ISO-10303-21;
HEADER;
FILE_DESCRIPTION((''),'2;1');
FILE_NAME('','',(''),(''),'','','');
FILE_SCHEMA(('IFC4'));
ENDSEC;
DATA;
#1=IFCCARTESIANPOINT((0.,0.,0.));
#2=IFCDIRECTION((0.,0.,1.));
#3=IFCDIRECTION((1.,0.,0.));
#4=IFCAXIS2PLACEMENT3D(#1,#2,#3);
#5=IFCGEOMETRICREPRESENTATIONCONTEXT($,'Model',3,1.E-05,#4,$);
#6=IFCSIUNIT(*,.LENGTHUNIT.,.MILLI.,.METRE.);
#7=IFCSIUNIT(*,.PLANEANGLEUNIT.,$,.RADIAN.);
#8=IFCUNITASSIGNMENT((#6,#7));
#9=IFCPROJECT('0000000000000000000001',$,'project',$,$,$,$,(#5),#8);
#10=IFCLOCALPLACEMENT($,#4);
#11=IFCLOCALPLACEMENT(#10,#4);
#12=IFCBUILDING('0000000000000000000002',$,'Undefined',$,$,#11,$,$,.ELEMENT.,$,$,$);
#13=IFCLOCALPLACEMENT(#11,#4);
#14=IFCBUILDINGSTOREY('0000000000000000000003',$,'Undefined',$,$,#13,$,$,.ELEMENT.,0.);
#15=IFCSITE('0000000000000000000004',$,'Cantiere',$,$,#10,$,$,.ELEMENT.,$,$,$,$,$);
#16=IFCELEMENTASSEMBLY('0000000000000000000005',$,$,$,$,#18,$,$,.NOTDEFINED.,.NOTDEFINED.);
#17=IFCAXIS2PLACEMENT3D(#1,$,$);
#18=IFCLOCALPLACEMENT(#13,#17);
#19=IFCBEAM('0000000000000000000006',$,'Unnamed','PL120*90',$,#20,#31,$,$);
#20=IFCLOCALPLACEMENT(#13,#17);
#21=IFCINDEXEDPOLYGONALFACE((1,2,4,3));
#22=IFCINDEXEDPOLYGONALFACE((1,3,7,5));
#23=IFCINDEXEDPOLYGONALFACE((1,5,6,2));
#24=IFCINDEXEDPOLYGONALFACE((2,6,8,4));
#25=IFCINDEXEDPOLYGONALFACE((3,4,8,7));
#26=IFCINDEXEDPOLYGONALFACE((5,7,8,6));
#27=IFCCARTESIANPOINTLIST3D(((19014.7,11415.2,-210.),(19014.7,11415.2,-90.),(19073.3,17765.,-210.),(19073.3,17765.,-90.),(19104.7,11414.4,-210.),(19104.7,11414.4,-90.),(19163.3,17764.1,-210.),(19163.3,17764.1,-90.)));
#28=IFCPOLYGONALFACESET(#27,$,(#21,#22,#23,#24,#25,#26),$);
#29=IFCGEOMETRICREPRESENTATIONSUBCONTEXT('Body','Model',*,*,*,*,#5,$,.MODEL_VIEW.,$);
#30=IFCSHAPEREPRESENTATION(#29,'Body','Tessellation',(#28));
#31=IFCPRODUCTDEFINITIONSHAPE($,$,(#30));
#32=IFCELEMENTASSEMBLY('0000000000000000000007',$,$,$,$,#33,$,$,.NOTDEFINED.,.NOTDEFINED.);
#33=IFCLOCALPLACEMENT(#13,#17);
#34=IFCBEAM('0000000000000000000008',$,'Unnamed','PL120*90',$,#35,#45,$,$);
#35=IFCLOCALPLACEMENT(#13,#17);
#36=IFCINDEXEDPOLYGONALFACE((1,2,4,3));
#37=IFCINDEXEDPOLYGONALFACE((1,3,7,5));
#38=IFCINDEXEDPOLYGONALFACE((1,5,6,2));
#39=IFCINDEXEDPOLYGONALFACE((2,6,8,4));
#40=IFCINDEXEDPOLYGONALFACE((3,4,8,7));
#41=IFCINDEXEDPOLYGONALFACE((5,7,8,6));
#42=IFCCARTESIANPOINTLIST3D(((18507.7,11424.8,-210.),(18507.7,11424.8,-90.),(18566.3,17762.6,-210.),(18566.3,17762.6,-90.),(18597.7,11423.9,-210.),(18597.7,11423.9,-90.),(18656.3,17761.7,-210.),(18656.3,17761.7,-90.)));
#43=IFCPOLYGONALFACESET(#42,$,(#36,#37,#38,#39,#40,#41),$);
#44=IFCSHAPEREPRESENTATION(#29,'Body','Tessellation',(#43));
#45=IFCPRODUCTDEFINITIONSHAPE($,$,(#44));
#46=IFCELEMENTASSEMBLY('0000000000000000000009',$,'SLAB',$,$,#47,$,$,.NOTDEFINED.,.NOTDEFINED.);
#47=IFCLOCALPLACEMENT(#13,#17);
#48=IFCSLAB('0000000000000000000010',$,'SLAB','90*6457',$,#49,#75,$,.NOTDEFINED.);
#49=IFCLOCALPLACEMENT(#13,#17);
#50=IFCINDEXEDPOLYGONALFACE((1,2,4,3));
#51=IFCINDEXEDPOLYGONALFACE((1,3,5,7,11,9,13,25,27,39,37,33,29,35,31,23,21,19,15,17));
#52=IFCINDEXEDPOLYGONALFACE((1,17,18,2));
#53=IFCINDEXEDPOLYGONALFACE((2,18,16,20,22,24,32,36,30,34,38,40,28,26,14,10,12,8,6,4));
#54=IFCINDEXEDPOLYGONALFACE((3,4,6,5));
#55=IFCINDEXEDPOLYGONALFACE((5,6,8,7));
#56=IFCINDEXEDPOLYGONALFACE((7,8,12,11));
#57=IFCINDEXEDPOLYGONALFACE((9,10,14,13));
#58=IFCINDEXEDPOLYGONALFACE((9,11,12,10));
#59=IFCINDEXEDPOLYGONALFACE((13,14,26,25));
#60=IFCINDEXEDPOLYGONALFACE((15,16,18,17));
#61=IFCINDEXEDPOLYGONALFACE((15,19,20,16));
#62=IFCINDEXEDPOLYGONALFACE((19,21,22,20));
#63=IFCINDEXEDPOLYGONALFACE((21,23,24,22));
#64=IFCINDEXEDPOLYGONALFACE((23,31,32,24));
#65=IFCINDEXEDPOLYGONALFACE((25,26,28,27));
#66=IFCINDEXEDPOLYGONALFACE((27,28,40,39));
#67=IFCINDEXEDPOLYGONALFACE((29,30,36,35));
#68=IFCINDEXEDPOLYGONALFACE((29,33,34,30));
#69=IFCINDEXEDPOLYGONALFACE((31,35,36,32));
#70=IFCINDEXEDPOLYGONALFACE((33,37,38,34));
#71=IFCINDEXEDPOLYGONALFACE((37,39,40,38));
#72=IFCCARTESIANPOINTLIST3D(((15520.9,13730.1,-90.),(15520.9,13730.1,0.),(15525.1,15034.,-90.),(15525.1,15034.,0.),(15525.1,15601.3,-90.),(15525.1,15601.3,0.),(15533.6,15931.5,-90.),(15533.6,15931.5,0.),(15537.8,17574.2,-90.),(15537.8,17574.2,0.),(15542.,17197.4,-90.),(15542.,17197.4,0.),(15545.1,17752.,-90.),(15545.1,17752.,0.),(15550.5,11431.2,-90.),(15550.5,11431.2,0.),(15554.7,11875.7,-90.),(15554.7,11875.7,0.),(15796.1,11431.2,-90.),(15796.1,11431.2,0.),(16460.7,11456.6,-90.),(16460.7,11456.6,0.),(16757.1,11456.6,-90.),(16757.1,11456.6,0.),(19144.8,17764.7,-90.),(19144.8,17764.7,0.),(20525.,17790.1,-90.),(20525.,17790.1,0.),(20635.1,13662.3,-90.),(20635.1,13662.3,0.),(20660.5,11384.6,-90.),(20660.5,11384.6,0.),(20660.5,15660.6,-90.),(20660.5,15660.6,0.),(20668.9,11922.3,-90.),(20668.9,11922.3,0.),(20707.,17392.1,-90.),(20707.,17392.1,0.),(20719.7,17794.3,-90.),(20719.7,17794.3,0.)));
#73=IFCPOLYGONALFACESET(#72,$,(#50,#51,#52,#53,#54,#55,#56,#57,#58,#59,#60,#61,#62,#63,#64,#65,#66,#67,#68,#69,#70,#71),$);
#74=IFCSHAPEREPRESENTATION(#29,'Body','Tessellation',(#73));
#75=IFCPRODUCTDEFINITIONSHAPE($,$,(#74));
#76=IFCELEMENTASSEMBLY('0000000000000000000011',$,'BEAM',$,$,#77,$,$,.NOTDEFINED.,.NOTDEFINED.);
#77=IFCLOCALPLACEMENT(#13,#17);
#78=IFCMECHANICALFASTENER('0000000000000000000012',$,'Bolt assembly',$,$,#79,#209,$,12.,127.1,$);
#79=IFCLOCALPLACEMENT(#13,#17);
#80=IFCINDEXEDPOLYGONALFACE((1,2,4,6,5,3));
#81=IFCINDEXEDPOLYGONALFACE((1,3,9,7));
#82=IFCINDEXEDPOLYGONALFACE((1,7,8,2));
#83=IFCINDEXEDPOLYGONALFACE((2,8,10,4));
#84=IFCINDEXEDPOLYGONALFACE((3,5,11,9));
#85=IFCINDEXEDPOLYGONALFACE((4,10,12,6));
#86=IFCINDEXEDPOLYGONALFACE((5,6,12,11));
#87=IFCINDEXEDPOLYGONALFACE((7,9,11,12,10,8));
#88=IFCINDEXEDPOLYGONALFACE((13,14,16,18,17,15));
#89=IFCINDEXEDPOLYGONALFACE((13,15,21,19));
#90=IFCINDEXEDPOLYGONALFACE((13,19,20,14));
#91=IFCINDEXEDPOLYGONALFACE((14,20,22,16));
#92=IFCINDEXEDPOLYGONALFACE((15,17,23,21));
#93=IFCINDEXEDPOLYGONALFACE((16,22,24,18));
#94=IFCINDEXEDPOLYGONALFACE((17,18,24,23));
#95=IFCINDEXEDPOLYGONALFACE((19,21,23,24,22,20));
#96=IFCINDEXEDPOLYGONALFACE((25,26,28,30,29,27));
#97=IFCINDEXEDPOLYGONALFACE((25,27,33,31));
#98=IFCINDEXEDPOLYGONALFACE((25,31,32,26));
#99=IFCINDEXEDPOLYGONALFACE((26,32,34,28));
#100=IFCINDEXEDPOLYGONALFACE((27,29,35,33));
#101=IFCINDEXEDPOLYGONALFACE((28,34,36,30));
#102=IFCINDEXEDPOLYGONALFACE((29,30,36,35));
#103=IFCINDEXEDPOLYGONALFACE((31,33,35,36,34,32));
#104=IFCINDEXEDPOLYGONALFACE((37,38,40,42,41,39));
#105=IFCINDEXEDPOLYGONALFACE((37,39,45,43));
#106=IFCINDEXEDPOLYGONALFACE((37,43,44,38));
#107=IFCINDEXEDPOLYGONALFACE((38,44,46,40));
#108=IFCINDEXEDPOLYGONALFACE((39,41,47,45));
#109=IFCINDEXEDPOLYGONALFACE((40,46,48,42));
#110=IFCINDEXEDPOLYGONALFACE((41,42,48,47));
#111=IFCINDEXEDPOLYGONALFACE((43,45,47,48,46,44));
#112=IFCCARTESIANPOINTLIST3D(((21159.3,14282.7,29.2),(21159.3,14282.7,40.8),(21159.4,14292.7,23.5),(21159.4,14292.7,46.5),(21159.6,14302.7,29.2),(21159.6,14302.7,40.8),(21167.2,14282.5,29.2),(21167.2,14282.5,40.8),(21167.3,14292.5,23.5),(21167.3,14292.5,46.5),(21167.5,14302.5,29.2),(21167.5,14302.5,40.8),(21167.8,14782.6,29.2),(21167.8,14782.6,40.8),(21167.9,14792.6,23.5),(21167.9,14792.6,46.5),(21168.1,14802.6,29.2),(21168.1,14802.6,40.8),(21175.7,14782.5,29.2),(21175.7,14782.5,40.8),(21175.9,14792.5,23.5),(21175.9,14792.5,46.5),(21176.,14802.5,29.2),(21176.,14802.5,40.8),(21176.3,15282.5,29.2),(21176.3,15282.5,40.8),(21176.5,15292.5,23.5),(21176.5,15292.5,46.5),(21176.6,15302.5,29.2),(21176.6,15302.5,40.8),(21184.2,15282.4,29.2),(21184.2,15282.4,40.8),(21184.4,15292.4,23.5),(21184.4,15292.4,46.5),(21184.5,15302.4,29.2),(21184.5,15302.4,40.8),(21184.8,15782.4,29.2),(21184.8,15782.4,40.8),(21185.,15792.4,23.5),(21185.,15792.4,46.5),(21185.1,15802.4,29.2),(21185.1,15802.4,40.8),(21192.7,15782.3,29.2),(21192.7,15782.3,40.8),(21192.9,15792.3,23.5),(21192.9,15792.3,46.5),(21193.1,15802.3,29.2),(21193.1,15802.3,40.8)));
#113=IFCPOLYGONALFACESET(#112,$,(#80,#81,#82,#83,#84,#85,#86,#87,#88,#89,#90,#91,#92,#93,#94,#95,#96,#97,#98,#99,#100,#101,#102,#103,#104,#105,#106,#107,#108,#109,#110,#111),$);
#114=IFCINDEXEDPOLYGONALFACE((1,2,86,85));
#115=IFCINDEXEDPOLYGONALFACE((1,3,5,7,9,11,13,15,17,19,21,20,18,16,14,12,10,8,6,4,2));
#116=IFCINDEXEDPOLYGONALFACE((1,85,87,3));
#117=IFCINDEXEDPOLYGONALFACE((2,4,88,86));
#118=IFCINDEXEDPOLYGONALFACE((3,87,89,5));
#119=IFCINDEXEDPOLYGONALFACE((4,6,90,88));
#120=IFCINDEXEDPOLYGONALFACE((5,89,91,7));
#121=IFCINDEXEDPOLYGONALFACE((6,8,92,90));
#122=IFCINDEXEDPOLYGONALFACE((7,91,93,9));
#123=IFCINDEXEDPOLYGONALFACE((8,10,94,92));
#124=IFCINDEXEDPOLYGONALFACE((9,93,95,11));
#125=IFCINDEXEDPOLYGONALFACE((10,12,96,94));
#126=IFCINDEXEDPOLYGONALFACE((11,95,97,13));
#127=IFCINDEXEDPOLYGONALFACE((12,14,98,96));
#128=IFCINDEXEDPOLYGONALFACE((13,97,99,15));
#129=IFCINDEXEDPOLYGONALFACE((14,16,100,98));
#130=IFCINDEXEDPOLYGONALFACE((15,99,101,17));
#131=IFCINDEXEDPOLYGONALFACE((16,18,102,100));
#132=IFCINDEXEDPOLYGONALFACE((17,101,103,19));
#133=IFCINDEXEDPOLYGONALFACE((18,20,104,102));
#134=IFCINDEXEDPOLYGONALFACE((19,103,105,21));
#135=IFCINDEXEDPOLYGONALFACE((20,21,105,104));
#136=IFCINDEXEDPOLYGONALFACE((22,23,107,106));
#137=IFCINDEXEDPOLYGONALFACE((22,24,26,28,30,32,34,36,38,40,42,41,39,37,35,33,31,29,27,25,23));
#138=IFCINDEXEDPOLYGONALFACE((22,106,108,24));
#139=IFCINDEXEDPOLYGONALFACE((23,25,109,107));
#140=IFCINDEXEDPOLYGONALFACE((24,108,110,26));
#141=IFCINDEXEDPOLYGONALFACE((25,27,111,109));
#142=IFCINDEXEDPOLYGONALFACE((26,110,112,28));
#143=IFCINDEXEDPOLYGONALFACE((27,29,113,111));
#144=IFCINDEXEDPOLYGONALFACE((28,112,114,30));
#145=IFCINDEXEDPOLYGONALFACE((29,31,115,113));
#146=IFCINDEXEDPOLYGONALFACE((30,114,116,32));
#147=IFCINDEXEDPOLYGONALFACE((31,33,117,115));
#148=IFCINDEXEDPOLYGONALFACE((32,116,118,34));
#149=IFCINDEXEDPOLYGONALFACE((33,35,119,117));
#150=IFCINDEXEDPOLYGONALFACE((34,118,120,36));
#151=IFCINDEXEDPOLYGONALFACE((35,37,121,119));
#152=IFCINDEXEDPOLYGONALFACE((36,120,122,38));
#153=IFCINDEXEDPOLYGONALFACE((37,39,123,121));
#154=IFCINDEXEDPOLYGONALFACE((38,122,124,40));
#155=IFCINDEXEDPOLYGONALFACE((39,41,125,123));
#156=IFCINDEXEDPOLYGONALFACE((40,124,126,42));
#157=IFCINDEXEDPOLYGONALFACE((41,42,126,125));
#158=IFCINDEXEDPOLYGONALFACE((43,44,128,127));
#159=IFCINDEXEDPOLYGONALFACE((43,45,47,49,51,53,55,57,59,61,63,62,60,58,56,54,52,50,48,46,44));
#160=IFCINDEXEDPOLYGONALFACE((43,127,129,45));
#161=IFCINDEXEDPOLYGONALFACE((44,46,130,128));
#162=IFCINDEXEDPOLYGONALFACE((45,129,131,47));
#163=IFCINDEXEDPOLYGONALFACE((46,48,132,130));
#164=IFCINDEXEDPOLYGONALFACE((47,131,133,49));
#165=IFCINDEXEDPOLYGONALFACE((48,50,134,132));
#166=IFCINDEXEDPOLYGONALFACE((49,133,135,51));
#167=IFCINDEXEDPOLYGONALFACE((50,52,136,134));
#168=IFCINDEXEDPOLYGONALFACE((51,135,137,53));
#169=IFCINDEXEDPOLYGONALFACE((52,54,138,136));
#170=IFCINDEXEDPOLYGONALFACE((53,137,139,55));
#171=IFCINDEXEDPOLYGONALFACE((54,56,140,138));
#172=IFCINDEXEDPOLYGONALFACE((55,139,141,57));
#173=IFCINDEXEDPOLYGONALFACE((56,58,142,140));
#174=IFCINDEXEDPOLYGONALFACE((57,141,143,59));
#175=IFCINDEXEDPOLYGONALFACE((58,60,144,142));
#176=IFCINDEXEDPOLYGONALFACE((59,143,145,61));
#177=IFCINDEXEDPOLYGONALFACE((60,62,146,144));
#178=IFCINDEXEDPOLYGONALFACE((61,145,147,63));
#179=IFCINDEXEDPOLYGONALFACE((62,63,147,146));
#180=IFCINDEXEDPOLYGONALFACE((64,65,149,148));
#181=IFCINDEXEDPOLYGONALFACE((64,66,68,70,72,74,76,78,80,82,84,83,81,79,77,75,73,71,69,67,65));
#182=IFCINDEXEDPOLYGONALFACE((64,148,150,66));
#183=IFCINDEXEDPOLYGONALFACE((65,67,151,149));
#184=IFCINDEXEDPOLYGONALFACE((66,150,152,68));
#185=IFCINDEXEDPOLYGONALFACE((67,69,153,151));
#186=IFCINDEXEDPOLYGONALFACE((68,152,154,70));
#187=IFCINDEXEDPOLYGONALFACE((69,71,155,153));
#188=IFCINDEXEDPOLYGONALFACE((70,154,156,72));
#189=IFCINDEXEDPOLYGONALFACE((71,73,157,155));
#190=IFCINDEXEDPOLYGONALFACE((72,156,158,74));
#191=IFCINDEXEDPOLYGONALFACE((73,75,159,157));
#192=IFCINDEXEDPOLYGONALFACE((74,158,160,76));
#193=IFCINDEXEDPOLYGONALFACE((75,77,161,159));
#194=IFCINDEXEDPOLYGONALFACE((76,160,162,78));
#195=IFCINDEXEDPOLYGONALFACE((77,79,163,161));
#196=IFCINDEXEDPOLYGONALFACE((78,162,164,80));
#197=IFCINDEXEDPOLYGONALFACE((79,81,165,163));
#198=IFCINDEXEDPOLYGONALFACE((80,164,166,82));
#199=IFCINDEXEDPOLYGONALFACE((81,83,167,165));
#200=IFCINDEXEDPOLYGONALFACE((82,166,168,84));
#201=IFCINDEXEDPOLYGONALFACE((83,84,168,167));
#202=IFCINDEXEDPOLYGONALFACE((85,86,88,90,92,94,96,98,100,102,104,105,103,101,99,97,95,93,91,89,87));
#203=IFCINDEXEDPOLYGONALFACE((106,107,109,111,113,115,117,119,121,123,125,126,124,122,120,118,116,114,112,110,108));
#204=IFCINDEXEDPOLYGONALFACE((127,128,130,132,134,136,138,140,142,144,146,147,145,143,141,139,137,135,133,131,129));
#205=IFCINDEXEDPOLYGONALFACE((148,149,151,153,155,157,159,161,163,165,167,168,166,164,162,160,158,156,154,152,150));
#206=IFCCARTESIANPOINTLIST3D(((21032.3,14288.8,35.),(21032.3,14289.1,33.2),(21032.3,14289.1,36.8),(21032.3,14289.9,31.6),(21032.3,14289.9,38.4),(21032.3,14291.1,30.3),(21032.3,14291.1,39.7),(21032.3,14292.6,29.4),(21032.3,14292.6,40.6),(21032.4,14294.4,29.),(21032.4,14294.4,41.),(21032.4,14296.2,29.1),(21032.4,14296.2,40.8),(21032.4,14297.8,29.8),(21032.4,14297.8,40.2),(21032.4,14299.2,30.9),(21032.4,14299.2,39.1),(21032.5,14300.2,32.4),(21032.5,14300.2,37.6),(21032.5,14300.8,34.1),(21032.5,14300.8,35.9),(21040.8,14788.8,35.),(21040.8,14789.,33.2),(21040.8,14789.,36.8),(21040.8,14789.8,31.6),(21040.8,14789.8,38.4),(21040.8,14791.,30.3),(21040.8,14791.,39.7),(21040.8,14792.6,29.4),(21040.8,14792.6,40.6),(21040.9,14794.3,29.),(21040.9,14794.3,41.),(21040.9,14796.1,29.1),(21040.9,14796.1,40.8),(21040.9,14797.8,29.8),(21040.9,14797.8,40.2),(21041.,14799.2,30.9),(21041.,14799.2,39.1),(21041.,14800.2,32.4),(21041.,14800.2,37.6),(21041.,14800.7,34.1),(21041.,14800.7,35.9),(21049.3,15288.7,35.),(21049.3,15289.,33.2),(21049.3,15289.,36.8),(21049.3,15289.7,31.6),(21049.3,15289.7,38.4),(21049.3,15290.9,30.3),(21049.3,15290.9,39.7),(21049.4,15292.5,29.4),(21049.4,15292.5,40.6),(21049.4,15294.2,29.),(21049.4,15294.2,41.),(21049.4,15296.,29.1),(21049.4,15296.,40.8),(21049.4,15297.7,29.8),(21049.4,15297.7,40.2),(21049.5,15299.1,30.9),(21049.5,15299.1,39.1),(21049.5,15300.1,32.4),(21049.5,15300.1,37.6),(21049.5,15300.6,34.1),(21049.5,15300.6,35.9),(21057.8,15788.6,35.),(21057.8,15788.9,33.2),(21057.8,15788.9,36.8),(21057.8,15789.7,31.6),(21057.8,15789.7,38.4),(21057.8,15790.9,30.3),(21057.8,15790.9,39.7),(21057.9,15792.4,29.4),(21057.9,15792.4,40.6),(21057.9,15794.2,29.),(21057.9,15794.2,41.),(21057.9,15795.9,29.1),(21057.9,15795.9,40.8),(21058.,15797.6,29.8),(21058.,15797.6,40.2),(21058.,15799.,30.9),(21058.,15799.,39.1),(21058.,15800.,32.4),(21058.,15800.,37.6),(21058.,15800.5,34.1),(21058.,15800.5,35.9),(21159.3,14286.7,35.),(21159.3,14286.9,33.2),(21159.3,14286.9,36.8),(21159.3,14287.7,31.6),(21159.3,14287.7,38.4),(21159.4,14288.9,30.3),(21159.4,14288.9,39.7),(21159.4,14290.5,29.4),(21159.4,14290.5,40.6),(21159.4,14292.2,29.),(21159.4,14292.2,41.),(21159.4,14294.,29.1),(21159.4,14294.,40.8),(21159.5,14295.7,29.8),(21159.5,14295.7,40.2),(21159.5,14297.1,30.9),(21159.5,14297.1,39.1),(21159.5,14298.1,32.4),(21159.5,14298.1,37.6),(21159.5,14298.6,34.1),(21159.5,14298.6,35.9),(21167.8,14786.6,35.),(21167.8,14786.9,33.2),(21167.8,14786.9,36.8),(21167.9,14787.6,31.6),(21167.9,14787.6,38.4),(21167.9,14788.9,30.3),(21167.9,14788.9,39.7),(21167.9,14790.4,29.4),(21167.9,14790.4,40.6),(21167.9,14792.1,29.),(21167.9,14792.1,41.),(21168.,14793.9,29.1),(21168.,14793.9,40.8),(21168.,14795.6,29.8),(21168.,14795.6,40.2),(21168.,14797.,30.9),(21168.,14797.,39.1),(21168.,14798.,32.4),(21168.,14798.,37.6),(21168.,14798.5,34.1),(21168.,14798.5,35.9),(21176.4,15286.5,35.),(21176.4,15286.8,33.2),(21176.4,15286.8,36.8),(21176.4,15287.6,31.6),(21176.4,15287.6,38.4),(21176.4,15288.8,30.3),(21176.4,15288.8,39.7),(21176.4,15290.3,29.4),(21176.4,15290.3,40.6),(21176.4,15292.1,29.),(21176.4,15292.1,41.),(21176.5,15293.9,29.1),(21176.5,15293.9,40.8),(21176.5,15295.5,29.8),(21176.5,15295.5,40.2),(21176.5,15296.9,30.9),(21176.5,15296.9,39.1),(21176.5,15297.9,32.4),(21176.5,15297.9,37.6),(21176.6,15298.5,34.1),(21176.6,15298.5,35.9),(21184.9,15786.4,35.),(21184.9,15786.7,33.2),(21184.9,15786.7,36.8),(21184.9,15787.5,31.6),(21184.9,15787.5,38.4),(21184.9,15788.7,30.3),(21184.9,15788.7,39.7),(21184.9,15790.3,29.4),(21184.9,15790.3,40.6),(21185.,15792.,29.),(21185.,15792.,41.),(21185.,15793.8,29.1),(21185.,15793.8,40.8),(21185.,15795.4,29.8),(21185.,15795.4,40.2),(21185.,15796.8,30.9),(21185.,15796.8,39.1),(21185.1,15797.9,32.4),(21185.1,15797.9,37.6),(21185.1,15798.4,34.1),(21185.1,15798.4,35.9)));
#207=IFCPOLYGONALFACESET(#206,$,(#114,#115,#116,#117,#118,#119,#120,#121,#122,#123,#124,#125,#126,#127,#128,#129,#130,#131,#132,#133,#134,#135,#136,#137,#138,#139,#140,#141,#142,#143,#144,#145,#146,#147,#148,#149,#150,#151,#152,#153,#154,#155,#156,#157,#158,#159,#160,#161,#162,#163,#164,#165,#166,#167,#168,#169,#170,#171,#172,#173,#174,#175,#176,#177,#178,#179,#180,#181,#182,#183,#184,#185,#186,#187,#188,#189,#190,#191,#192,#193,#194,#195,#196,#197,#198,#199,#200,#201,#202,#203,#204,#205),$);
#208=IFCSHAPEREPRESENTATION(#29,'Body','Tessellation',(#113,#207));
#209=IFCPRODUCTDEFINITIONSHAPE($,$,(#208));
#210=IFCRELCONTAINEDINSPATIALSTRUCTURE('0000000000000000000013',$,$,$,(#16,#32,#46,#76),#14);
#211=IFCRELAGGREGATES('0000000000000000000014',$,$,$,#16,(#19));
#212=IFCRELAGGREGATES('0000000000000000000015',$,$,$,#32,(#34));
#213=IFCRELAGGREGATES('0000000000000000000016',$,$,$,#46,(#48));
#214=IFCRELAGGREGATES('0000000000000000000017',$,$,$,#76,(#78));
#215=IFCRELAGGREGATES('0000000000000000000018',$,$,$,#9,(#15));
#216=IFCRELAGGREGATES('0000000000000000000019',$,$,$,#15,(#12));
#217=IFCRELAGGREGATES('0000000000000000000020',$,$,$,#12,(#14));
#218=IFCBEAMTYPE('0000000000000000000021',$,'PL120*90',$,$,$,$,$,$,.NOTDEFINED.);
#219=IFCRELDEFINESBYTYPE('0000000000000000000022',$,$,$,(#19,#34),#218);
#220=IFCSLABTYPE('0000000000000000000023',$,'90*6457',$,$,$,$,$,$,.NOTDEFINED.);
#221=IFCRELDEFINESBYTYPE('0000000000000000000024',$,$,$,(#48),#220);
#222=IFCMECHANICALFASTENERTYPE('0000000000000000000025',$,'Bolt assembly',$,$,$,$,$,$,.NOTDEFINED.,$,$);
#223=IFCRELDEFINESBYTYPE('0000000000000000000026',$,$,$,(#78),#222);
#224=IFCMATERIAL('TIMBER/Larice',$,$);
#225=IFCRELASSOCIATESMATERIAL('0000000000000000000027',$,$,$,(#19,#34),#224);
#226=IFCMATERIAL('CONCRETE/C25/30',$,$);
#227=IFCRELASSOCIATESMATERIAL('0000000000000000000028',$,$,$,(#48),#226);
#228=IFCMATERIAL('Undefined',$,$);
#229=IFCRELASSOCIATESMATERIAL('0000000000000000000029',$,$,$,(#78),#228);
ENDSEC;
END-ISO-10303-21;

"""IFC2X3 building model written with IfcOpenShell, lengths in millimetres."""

from ifc_helpers import new_model, si_unit, frame, origin_with_axes, origin_2d_with_axis, place, context, subcontext, project, spatial, polyline, rectangle, circle, outline, extrude, source, transform, mapped, material, type_object, element, aggregate, save


model = new_model("IFC2X3")

# Units and contexts
model_context = context("Model", 3, precision=1e-05, world=origin_with_axes())
body_context = subcontext(model_context, "Body", "Model", "MODEL_VIEW")
ifc_project = project(units=[si_unit("LENGTHUNIT", "METRE", prefix="MILLI"), si_unit("PLANEANGLEUNIT", "RADIAN")], contexts=[model_context])

# Site, building, storey
site_placement = place(None, origin_with_axes())
site = spatial("IfcSite", under=ifc_project, at=site_placement, Name="Cantiere", CompositionType="ELEMENT")
building_placement = place(site_placement, origin_with_axes())
building = spatial("IfcBuilding", under=site, at=building_placement, Name="Undefined", CompositionType="ELEMENT")
storey_placement = place(building_placement, origin_with_axes())
storey = spatial("IfcBuildingStorey", under=building, at=storey_placement, Name="Undefined", CompositionType="ELEMENT", Elevation=0.0)

# Element assemblies, beams
ifc_material_1 = material(Name="TIMBER/Larice")
beam_type_1 = type_object("IfcBeamType", Name="PL120*90", PredefinedType="NOTDEFINED")
assembly_1_placement = place(storey_placement, origin_with_axes())
assembly_1 = element("IfcElementAssembly", 1, at=assembly_1_placement, inside=storey, AssemblyPlace="NOTDEFINED", PredefinedType="NOTDEFINED")
beam_1_placement = place(assembly_1_placement, frame((19118.3, 17764.6, -150.0), z_axis=(0.0, 0.0, 1.0), x_axis=(-0.009237, -0.999957, 0.0)))
beam_1 = element("IfcBeam", 2, at=beam_1_placement, type_object=beam_type_1, material=ifc_material_1, Name="Unnamed", Description="PL120*90", context=body_context, shape_type="SweptSolid", body=[
    extrude(rectangle(XDim=90.0, YDim=120.0, at=origin_2d_with_axis()), frame((6350.0, 0.0, 0.0), z_axis=(-1.0, 0.0, 0.0), x_axis=(0.0, -1.0, 0.0)), (0.0, 0.0, 1.0), 6350.0),
])
aggregate(assembly_1, [beam_1])
assembly_2_placement = place(storey_placement, origin_with_axes())
assembly_2 = element("IfcElementAssembly", 3, at=assembly_2_placement, inside=storey, AssemblyPlace="NOTDEFINED", PredefinedType="NOTDEFINED")
beam_2_placement = place(assembly_2_placement, frame((18611.3, 17762.2, -150.0), z_axis=(0.0, 0.0, 1.0), x_axis=(-0.009237, -0.999957, 0.0)))
beam_2 = element("IfcBeam", 4, at=beam_2_placement, type_object=beam_type_1, material=ifc_material_1, Name="Unnamed", Description="PL120*90", context=body_context, shape_type="SweptSolid", body=[
    extrude(rectangle(XDim=90.0, YDim=120.0, at=origin_2d_with_axis()), frame((6338.1, 0.0, 0.0), z_axis=(-1.0, 0.0, 0.0), x_axis=(0.0, -1.0, 0.0)), (0.0, 0.0, 1.0), 6338.1),
])
aggregate(assembly_2, [beam_2])

# Element assembly, slab
assembly_3_placement = place(storey_placement, origin_with_axes())
assembly_3 = element("IfcElementAssembly", 5, at=assembly_3_placement, inside=storey, Name="SLAB", AssemblyPlace="NOTDEFINED", PredefinedType="NOTDEFINED")
ifc_material_2 = material(Name="CONCRETE/C25/30")
slab_type = type_object("IfcSlabType", Name="90*6457", PredefinedType="NOTDEFINED")
slab_placement = place(assembly_3_placement, frame((19144.8, 17764.7, -45.0), z_axis=(0.0, 0.0, 1.0), x_axis=(-0.999994, -0.003528, 0.0)))
slab = element("IfcSlab", 6, at=slab_placement, type_object=slab_type, material=ifc_material_2, Name="SLAB", Description="90*6457", PredefinedType="NOTDEFINED", context=body_context, shape_type="SweptSolid", body=[
    extrude(outline(polyline([(0.0, 0.0), (3599.8, 0.0), (3607.7, 177.8), (3604.8, 554.6), (3617.7, 1820.4), (3627.3, 2150.6), (3629.3, 2717.9), (3638.2, 4021.8), (3610.8, 5876.2), (3616.6, 6320.7), (3371.1, 6321.6), (2706.3, 6298.6), (2410.0, 6299.6), (-1493.1, 6385.3), (-1503.5, 5847.7), (-1475.7, 4107.6), (-1508.2, 2109.4), (-1560.9, 378.1), (-1575.0, -24.1), (-1380.2, -20.5), (0.0, 0.0)])), frame((0.0, 0.0, -45.0), z_axis=(0.0, 0.0, 1.0), x_axis=(1.0, 0.0, 0.0)), (0.0, 0.0, 1.0), 90.0),
])
aggregate(assembly_3, [slab])

# Shared definitions
mechanical_fastener_type = type_object("IfcMechanicalFastenerType", Name="Bolt assembly")

# Element assembly, mechanical fastener
assembly_4_placement = place(storey_placement, origin_with_axes())
assembly_4 = element("IfcElementAssembly", 7, at=assembly_4_placement, inside=storey, Name="BEAM", AssemblyPlace="NOTDEFINED", PredefinedType="NOTDEFINED")
ifc_material_3 = material(Name="Undefined")
shared_shape_1 = source(origin_with_axes(), body_context, "Body", "SweptSolid", [
    extrude(outline(polyline([(10.0, -5.8), (10.0, 5.8), (0.0, 11.5), (-10.0, 5.8), (-10.0, -5.8), (0.0, -11.5), (10.0, -5.8)])), frame((0.0, -135.0, 0.0), z_axis=(0.0, 1.0, 0.0), x_axis=(1.0, 0.0, 0.0)), (0.0, 0.0, 1.0), 7.9),
    extrude(circle(Radius=6.0, at=origin_2d_with_axis()), frame((0.0, -127.1, 0.0), z_axis=(0.0, 1.0, 0.0), x_axis=(1.0, 0.0, 0.0)), (0.0, 0.0, 1.0), 127.1),
])
mechanical_fastener_1_placement = place(assembly_4_placement, frame((21057.9, 15794.6, 35.0), z_axis=(0.0, 0.000001, -1.0), x_axis=(-0.01703, -0.999855, 0.0)))
mechanical_fastener_1 = element("IfcMechanicalFastener", 8, at=mechanical_fastener_1_placement, type_object=mechanical_fastener_type, material=ifc_material_3, Name="Bolt assembly", NominalDiameter=12.0, NominalLength=127.1, context=body_context, shape_type="MappedRepresentation", body=[
    mapped(shared_shape_1, transform((0.0, 0.0, 0.0))),
    mapped(shared_shape_1, transform((500.0, 0.0, 0.0))),
    mapped(shared_shape_1, transform((1000.0, 0.0, 0.0))),
    mapped(shared_shape_1, transform((1500.0, 0.0, 0.0))),
])
aggregate(assembly_4, [mechanical_fastener_1])

save(model, "model.ifc")
